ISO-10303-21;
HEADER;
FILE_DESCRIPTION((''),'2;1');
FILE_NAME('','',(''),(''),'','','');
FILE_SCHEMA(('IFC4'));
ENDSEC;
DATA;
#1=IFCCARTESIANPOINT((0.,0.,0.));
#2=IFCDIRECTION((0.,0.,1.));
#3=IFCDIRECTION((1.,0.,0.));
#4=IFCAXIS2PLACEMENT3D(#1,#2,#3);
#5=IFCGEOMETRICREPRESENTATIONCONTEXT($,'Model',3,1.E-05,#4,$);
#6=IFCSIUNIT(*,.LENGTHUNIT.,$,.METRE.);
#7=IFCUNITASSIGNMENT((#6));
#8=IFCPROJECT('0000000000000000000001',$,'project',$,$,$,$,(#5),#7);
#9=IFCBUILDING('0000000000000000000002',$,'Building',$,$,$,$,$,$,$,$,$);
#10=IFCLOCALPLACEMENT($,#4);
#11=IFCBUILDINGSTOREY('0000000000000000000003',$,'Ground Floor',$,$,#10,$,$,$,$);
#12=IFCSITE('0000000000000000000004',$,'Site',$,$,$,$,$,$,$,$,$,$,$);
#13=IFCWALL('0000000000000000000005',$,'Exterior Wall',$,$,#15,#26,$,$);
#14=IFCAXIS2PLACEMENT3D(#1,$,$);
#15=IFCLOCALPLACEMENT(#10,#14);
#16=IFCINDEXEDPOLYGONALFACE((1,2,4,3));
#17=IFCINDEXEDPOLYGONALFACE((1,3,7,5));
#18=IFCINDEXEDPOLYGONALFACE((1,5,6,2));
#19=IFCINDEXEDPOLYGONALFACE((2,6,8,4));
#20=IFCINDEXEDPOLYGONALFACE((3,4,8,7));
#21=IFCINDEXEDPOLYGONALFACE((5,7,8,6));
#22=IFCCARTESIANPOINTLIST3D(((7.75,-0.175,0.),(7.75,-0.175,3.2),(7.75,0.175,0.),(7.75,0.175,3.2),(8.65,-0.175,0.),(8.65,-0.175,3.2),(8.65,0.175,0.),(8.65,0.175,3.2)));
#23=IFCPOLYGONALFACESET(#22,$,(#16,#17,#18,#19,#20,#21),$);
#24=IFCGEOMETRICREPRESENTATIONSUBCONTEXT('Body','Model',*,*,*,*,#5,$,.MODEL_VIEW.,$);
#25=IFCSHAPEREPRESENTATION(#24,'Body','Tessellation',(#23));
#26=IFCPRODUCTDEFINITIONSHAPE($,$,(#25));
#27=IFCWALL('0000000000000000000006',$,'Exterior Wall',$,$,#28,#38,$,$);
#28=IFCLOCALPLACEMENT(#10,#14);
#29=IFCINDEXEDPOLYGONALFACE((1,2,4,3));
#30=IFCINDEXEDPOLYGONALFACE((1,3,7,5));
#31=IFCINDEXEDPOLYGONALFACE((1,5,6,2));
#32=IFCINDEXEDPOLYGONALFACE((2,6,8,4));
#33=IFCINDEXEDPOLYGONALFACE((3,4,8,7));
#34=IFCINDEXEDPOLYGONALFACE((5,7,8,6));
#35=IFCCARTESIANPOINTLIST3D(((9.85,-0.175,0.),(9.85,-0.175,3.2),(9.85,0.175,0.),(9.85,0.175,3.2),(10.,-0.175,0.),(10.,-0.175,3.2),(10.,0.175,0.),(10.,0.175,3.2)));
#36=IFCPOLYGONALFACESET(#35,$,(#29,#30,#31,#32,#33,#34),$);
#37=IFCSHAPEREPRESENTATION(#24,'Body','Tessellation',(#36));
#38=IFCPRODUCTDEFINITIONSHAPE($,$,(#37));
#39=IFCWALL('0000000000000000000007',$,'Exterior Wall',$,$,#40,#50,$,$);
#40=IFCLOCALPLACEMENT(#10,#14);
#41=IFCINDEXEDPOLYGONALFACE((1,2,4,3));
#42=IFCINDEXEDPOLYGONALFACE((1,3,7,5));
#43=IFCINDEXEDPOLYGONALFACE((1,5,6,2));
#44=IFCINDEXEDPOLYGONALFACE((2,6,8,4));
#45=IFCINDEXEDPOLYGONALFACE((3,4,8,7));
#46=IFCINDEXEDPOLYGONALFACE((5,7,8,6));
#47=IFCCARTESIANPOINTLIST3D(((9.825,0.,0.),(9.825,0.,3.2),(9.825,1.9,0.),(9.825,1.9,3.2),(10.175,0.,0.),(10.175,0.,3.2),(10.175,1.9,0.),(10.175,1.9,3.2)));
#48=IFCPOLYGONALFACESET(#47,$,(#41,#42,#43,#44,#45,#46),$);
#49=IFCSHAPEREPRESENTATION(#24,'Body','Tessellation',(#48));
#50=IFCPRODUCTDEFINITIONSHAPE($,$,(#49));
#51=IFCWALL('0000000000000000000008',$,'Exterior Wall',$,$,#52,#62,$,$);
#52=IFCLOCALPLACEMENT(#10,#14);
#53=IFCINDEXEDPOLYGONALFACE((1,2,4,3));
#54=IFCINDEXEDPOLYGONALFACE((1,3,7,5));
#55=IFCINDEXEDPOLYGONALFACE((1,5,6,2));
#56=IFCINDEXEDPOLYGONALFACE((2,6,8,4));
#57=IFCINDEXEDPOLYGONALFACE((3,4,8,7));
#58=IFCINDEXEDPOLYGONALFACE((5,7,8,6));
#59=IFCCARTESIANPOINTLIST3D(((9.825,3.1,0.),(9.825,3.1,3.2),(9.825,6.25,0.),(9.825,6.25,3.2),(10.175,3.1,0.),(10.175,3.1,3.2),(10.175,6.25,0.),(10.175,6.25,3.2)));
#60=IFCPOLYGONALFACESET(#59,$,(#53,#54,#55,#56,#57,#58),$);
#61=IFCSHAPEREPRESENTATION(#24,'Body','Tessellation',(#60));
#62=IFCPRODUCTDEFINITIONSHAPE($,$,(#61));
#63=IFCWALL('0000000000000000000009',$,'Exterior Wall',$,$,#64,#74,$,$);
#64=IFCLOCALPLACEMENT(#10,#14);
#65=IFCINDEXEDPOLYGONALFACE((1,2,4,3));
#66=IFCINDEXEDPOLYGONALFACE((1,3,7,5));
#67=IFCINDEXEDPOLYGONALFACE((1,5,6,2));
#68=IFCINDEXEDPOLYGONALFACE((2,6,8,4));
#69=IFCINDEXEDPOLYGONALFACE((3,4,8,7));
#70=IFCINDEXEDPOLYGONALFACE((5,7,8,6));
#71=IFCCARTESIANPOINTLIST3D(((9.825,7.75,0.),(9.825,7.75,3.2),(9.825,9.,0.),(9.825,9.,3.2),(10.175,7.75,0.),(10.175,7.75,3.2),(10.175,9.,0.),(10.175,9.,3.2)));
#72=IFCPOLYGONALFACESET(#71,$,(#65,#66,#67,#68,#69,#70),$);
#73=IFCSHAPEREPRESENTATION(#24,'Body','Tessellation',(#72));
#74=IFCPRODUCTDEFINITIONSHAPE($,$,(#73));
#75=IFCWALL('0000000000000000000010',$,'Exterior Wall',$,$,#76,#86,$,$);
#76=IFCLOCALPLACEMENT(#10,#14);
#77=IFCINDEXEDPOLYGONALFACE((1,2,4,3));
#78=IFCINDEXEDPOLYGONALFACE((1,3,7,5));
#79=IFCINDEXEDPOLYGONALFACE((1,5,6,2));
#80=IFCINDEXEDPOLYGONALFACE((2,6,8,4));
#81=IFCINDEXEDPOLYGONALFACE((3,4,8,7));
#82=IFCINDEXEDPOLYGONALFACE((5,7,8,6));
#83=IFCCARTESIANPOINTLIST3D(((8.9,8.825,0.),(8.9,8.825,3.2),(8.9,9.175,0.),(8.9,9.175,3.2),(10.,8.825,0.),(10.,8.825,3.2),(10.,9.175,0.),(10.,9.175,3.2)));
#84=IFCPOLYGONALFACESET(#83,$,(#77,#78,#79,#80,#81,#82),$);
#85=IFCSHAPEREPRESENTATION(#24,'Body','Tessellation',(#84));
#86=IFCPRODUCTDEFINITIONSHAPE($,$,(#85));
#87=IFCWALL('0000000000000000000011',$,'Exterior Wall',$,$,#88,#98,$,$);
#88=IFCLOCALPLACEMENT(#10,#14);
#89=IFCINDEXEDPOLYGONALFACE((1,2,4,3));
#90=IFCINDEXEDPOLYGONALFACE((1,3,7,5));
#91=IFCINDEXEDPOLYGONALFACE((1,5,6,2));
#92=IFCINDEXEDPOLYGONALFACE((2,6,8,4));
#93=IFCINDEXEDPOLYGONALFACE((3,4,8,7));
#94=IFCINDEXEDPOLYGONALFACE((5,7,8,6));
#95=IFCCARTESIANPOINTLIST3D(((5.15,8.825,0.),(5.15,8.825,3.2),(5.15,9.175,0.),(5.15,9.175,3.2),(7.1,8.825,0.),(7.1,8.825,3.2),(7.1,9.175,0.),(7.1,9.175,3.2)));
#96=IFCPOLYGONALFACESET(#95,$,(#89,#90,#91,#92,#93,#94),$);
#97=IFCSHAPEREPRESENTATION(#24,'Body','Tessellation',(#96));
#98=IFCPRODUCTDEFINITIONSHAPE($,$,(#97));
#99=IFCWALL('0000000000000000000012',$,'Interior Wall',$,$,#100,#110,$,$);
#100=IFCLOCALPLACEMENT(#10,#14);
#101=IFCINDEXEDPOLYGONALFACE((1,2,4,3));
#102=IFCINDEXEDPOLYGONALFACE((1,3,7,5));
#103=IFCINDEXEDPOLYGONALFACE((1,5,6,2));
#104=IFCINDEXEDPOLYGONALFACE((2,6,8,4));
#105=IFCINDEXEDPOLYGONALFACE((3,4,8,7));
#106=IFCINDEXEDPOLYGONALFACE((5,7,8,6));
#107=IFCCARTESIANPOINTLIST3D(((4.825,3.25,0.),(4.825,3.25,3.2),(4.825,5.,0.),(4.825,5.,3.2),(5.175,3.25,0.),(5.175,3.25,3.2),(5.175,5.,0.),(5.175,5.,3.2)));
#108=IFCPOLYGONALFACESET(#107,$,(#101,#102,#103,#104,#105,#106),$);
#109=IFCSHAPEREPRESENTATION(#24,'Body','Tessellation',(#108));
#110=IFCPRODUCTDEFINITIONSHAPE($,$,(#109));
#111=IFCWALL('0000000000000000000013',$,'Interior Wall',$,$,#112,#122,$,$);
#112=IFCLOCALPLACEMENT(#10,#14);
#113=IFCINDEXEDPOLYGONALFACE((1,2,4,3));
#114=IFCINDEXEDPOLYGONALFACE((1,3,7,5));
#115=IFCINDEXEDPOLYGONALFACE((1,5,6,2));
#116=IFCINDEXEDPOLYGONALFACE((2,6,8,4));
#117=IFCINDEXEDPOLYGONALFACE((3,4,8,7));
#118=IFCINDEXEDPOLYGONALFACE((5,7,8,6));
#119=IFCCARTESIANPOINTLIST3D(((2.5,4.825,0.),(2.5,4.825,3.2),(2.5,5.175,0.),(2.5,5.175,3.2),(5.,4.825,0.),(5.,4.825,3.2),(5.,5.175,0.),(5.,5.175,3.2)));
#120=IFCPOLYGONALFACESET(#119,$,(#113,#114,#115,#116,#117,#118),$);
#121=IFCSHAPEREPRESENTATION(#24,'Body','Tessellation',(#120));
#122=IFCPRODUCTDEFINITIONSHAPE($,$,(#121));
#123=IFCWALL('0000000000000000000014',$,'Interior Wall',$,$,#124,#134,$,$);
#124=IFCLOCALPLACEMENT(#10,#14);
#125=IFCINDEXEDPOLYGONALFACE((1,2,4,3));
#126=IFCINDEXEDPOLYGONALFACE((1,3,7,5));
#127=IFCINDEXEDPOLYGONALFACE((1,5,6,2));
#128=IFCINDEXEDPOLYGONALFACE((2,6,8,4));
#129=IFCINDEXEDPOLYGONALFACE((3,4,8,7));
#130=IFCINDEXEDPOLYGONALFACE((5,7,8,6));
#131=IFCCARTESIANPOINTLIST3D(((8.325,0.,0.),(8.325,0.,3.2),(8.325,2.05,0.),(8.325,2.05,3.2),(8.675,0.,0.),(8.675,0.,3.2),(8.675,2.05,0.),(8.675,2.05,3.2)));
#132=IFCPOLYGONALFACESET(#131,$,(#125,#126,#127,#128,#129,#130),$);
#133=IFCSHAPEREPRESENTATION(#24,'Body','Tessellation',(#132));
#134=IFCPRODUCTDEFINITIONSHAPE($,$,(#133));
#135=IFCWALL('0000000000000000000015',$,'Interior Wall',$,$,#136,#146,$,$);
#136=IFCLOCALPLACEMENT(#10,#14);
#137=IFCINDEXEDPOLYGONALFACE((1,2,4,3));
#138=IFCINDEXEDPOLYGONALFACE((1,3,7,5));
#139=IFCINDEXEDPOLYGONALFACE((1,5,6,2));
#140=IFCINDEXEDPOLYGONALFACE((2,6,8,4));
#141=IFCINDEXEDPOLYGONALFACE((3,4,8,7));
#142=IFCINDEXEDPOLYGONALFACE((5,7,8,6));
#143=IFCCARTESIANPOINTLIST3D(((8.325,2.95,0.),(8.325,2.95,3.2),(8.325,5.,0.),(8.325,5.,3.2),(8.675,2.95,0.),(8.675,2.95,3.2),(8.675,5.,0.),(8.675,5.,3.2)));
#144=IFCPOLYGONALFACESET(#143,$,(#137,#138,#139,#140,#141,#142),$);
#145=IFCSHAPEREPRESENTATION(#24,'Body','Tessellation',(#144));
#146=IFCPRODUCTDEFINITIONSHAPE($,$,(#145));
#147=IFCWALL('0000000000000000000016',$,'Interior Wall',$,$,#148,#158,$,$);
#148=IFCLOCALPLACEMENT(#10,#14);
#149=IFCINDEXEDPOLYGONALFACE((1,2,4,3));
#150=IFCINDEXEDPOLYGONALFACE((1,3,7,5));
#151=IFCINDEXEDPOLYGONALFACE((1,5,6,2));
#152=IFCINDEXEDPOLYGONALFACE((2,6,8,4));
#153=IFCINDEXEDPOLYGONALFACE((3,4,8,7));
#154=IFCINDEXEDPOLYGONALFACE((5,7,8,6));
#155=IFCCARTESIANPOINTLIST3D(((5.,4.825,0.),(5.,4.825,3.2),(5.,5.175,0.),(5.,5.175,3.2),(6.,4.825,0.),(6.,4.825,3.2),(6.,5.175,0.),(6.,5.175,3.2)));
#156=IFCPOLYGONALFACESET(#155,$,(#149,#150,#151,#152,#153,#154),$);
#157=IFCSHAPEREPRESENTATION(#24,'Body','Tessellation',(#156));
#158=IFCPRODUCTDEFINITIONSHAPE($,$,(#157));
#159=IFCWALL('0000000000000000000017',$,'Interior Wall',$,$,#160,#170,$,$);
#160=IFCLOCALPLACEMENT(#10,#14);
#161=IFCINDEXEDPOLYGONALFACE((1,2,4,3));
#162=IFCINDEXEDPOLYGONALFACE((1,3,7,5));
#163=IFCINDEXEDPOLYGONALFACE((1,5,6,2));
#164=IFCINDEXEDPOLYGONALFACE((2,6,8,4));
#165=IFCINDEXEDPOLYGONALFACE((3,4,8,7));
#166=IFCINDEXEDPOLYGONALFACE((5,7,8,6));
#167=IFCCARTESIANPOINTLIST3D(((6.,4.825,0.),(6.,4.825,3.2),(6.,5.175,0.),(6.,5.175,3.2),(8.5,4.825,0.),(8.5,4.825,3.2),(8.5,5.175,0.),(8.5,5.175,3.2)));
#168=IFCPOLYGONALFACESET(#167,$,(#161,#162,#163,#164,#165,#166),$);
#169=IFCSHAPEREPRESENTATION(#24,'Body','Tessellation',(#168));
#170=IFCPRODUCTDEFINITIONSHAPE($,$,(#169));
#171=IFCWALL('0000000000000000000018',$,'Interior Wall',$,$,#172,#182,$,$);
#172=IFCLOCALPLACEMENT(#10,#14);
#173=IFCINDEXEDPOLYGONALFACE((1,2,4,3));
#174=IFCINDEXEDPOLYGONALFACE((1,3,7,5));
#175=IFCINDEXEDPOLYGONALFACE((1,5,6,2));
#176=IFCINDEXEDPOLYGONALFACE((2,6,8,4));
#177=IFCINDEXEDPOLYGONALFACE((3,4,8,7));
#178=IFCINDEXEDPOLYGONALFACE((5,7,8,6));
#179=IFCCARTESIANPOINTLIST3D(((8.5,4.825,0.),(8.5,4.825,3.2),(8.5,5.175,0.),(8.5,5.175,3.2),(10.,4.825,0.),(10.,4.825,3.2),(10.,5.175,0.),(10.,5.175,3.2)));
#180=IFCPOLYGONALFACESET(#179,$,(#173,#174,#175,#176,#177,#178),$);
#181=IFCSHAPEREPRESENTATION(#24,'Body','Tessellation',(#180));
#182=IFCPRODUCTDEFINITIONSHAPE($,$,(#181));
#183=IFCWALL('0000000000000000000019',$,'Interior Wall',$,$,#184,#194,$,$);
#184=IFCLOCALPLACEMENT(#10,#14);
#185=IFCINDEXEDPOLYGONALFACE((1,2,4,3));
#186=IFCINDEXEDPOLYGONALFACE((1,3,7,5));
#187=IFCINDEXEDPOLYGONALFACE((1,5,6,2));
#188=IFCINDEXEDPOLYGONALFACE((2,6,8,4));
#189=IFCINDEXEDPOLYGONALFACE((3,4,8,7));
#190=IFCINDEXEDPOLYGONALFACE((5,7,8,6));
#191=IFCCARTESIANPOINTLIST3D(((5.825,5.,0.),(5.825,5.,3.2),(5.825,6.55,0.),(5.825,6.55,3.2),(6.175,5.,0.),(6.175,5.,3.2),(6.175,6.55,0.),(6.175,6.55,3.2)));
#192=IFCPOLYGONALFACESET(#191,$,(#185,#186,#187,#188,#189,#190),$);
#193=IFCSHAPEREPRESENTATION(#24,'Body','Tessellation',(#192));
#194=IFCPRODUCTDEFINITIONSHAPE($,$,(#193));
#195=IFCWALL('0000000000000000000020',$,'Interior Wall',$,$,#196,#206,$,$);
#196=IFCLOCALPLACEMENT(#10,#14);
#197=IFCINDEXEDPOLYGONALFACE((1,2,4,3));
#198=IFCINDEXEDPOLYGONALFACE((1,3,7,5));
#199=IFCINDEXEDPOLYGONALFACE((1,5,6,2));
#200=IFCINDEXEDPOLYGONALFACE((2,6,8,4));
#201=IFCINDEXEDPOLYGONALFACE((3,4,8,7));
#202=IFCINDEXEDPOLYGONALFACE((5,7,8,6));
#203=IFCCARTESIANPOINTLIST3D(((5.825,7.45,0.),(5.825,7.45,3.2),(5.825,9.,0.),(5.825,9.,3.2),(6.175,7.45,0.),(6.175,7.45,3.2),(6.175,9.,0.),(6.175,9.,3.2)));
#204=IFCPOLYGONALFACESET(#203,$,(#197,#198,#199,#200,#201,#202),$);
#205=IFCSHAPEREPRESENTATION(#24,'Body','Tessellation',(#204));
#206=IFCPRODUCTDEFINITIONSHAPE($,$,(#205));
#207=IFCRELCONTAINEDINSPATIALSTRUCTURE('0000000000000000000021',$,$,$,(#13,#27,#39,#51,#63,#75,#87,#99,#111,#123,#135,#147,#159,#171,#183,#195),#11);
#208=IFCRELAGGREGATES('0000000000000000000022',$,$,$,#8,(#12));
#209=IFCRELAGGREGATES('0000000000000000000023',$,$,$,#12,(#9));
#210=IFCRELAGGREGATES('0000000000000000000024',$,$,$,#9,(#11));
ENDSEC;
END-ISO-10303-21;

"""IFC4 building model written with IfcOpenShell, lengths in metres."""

from ifc_helpers import new_model, si_unit, frame, origin_with_axes, place, context, subcontext, project, spatial, indexed_curve, outline, extrude, element, save


model = new_model("IFC4")

# Units and contexts
model_context = context("Model", 3, precision=1e-05, world=origin_with_axes())
body_context = subcontext(model_context, "Body", "Model", "MODEL_VIEW")
ifc_project = project(units=[si_unit("LENGTHUNIT", "METRE")], contexts=[model_context])

# Site, building, storey
site = spatial("IfcSite", under=ifc_project, Name="Site")
building = spatial("IfcBuilding", under=site, Name="Building")
storey_placement = place(None, origin_with_axes())
storey = spatial("IfcBuildingStorey", under=building, at=storey_placement, Name="Ground Floor")

# Walls
wall_1_placement = place(storey_placement, frame((7.75, 0.0, 0.0), z_axis=(0.0, 0.0, 1.0), x_axis=(1.0, 0.0, 0.0)))
element("IfcWall", 1, at=wall_1_placement, inside=storey, Name="Exterior Wall", context=body_context, shape_type="SweptSolid", body=[
    extrude(outline(indexed_curve([(0.0, 0.0), (0.0, 0.35), (0.9, 0.35), (0.9, 0.0), (0.0, 0.0)], self_intersect=False)), frame((0.0, -0.175, 0.0), z_axis=(0.0, 0.0, 1.0), x_axis=(1.0, 0.0, 0.0)), (0.0, 0.0, 1.0), 3.2),
])
wall_2_placement = place(storey_placement, frame((9.85, 0.0, 0.0), z_axis=(0.0, 0.0, 1.0), x_axis=(1.0, 0.0, 0.0)))
element("IfcWall", 2, at=wall_2_placement, inside=storey, Name="Exterior Wall", context=body_context, shape_type="SweptSolid", body=[
    extrude(outline(indexed_curve([(0.0, 0.0), (0.0, 0.35), (0.15, 0.35), (0.15, 0.0), (0.0, 0.0)], self_intersect=False)), frame((0.0, -0.175, 0.0), z_axis=(0.0, 0.0, 1.0), x_axis=(1.0, 0.0, 0.0)), (0.0, 0.0, 1.0), 3.2),
])
wall_3_placement = place(storey_placement, frame((10.0, 0.0, 0.0), z_axis=(0.0, 0.0, 1.0), x_axis=(0.0, 1.0, 0.0)))
element("IfcWall", 3, at=wall_3_placement, inside=storey, Name="Exterior Wall", context=body_context, shape_type="SweptSolid", body=[
    extrude(outline(indexed_curve([(0.0, 0.0), (0.0, 0.35), (1.9, 0.35), (1.9, 0.0), (0.0, 0.0)], self_intersect=False)), frame((0.0, -0.175, 0.0), z_axis=(0.0, 0.0, 1.0), x_axis=(1.0, 0.0, 0.0)), (0.0, 0.0, 1.0), 3.2),
])
wall_4_placement = place(storey_placement, frame((10.0, 3.1, 0.0), z_axis=(0.0, 0.0, 1.0), x_axis=(0.0, 1.0, 0.0)))
element("IfcWall", 4, at=wall_4_placement, inside=storey, Name="Exterior Wall", context=body_context, shape_type="SweptSolid", body=[
    extrude(outline(indexed_curve([(0.0, 0.0), (0.0, 0.35), (3.15, 0.35), (3.15, 0.0), (0.0, 0.0)], self_intersect=False)), frame((0.0, -0.175, 0.0), z_axis=(0.0, 0.0, 1.0), x_axis=(1.0, 0.0, 0.0)), (0.0, 0.0, 1.0), 3.2),
])
wall_5_placement = place(storey_placement, frame((10.0, 7.75, 0.0), z_axis=(0.0, 0.0, 1.0), x_axis=(0.0, 1.0, 0.0)))
element("IfcWall", 5, at=wall_5_placement, inside=storey, Name="Exterior Wall", context=body_context, shape_type="SweptSolid", body=[
    extrude(outline(indexed_curve([(0.0, 0.0), (0.0, 0.35), (1.25, 0.35), (1.25, 0.0), (0.0, 0.0)], self_intersect=False)), frame((0.0, -0.175, 0.0), z_axis=(0.0, 0.0, 1.0), x_axis=(1.0, 0.0, 0.0)), (0.0, 0.0, 1.0), 3.2),
])
wall_6_placement = place(storey_placement, frame((10.0, 9.0, 0.0), z_axis=(0.0, 0.0, 1.0), x_axis=(-1.0, 0.0, 0.0)))
element("IfcWall", 6, at=wall_6_placement, inside=storey, Name="Exterior Wall", context=body_context, shape_type="SweptSolid", body=[
    extrude(outline(indexed_curve([(0.0, 0.0), (0.0, 0.35), (1.1, 0.35), (1.1, 0.0), (0.0, 0.0)], self_intersect=False)), frame((0.0, -0.175, 0.0), z_axis=(0.0, 0.0, 1.0), x_axis=(1.0, 0.0, 0.0)), (0.0, 0.0, 1.0), 3.2),
])
wall_7_placement = place(storey_placement, frame((7.1, 9.0, 0.0), z_axis=(0.0, 0.0, 1.0), x_axis=(-1.0, 0.0, 0.0)))
element("IfcWall", 7, at=wall_7_placement, inside=storey, Name="Exterior Wall", context=body_context, shape_type="SweptSolid", body=[
    extrude(outline(indexed_curve([(0.0, 0.0), (0.0, 0.35), (1.95, 0.35), (1.95, 0.0), (0.0, 0.0)], self_intersect=False)), frame((0.0, -0.175, 0.0), z_axis=(0.0, 0.0, 1.0), x_axis=(1.0, 0.0, 0.0)), (0.0, 0.0, 1.0), 3.2),
])
wall_8_placement = place(storey_placement, frame((5.0, 3.25, 0.0), z_axis=(0.0, 0.0, 1.0), x_axis=(0.0, 1.0, 0.0)))
element("IfcWall", 8, at=wall_8_placement, inside=storey, Name="Interior Wall", context=body_context, shape_type="SweptSolid", body=[
    extrude(outline(indexed_curve([(0.0, 0.0), (0.0, 0.35), (1.75, 0.35), (1.75, 0.0), (0.0, 0.0)], self_intersect=False)), frame((0.0, -0.175, 0.0), z_axis=(0.0, 0.0, 1.0), x_axis=(1.0, 0.0, 0.0)), (0.0, 0.0, 1.0), 3.2),
])
wall_9_placement = place(storey_placement, frame((5.0, 5.0, 0.0), z_axis=(0.0, 0.0, 1.0), x_axis=(-1.0, 0.0, 0.0)))
element("IfcWall", 9, at=wall_9_placement, inside=storey, Name="Interior Wall", context=body_context, shape_type="SweptSolid", body=[
    extrude(outline(indexed_curve([(0.0, 0.0), (0.0, 0.35), (2.5, 0.35), (2.5, 0.0), (0.0, 0.0)], self_intersect=False)), frame((0.0, -0.175, 0.0), z_axis=(0.0, 0.0, 1.0), x_axis=(1.0, 0.0, 0.0)), (0.0, 0.0, 1.0), 3.2),
])
for number, where, z_axis, x_axis, name in (
    (10, (8.5, 0.0, 0.0), (0.0, 0.0, 1.0), (0.0, 1.0, 0.0), "Interior Wall"),
    (11, (8.5, 2.95, 0.0), (0.0, 0.0, 1.0), (0.0, 1.0, 0.0), "Interior Wall"),
):
    element("IfcWall", number, at=place(storey_placement, frame(where, z_axis=z_axis, x_axis=x_axis)), inside=storey, Name=name, context=body_context, shape_type="SweptSolid", body=[
        extrude(outline(indexed_curve([(0.0, 0.0), (0.0, 0.35), (2.05, 0.35), (2.05, 0.0), (0.0, 0.0)], self_intersect=False)), frame((0.0, -0.175, 0.0), z_axis=(0.0, 0.0, 1.0), x_axis=(1.0, 0.0, 0.0)), (0.0, 0.0, 1.0), 3.2),
    ])
wall_10_placement = place(storey_placement, frame((6.0, 5.0, 0.0), z_axis=(0.0, 0.0, 1.0), x_axis=(-1.0, 0.0, 0.0)))
element("IfcWall", 12, at=wall_10_placement, inside=storey, Name="Interior Wall", context=body_context, shape_type="SweptSolid", body=[
    extrude(outline(indexed_curve([(0.0, 0.0), (0.0, 0.35), (1.0, 0.35), (1.0, 0.0), (0.0, 0.0)], self_intersect=False)), frame((0.0, -0.175, 0.0), z_axis=(0.0, 0.0, 1.0), x_axis=(1.0, 0.0, 0.0)), (0.0, 0.0, 1.0), 3.2),
])
wall_11_placement = place(storey_placement, frame((8.5, 5.0, 0.0), z_axis=(0.0, 0.0, 1.0), x_axis=(-1.0, 0.0, 0.0)))
element("IfcWall", 13, at=wall_11_placement, inside=storey, Name="Interior Wall", context=body_context, shape_type="SweptSolid", body=[
    extrude(outline(indexed_curve([(0.0, 0.0), (0.0, 0.35), (2.5, 0.35), (2.5, 0.0), (0.0, 0.0)], self_intersect=False)), frame((0.0, -0.175, 0.0), z_axis=(0.0, 0.0, 1.0), x_axis=(1.0, 0.0, 0.0)), (0.0, 0.0, 1.0), 3.2),
])
wall_12_placement = place(storey_placement, frame((10.0, 5.0, 0.0), z_axis=(0.0, 0.0, 1.0), x_axis=(-1.0, 0.0, 0.0)))
element("IfcWall", 14, at=wall_12_placement, inside=storey, Name="Interior Wall", context=body_context, shape_type="SweptSolid", body=[
    extrude(outline(indexed_curve([(0.0, 0.0), (0.0, 0.35), (1.5, 0.35), (1.5, 0.0), (0.0, 0.0)], self_intersect=False)), frame((0.0, -0.175, 0.0), z_axis=(0.0, 0.0, 1.0), x_axis=(1.0, 0.0, 0.0)), (0.0, 0.0, 1.0), 3.2),
])
for number, where, z_axis, x_axis, name in (
    (15, (6.0, 5.0, 0.0), (0.0, 0.0, 1.0), (0.0, 1.0, 0.0), "Interior Wall"),
    (16, (6.0, 7.45, 0.0), (0.0, 0.0, 1.0), (0.0, 1.0, 0.0), "Interior Wall"),
):
    element("IfcWall", number, at=place(storey_placement, frame(where, z_axis=z_axis, x_axis=x_axis)), inside=storey, Name=name, context=body_context, shape_type="SweptSolid", body=[
        extrude(outline(indexed_curve([(0.0, 0.0), (0.0, 0.35), (1.55, 0.35), (1.55, 0.0), (0.0, 0.0)], self_intersect=False)), frame((0.0, -0.175, 0.0), z_axis=(0.0, 0.0, 1.0), x_axis=(1.0, 0.0, 0.0)), (0.0, 0.0, 1.0), 3.2),
    ])

save(model, "model.ifc")
